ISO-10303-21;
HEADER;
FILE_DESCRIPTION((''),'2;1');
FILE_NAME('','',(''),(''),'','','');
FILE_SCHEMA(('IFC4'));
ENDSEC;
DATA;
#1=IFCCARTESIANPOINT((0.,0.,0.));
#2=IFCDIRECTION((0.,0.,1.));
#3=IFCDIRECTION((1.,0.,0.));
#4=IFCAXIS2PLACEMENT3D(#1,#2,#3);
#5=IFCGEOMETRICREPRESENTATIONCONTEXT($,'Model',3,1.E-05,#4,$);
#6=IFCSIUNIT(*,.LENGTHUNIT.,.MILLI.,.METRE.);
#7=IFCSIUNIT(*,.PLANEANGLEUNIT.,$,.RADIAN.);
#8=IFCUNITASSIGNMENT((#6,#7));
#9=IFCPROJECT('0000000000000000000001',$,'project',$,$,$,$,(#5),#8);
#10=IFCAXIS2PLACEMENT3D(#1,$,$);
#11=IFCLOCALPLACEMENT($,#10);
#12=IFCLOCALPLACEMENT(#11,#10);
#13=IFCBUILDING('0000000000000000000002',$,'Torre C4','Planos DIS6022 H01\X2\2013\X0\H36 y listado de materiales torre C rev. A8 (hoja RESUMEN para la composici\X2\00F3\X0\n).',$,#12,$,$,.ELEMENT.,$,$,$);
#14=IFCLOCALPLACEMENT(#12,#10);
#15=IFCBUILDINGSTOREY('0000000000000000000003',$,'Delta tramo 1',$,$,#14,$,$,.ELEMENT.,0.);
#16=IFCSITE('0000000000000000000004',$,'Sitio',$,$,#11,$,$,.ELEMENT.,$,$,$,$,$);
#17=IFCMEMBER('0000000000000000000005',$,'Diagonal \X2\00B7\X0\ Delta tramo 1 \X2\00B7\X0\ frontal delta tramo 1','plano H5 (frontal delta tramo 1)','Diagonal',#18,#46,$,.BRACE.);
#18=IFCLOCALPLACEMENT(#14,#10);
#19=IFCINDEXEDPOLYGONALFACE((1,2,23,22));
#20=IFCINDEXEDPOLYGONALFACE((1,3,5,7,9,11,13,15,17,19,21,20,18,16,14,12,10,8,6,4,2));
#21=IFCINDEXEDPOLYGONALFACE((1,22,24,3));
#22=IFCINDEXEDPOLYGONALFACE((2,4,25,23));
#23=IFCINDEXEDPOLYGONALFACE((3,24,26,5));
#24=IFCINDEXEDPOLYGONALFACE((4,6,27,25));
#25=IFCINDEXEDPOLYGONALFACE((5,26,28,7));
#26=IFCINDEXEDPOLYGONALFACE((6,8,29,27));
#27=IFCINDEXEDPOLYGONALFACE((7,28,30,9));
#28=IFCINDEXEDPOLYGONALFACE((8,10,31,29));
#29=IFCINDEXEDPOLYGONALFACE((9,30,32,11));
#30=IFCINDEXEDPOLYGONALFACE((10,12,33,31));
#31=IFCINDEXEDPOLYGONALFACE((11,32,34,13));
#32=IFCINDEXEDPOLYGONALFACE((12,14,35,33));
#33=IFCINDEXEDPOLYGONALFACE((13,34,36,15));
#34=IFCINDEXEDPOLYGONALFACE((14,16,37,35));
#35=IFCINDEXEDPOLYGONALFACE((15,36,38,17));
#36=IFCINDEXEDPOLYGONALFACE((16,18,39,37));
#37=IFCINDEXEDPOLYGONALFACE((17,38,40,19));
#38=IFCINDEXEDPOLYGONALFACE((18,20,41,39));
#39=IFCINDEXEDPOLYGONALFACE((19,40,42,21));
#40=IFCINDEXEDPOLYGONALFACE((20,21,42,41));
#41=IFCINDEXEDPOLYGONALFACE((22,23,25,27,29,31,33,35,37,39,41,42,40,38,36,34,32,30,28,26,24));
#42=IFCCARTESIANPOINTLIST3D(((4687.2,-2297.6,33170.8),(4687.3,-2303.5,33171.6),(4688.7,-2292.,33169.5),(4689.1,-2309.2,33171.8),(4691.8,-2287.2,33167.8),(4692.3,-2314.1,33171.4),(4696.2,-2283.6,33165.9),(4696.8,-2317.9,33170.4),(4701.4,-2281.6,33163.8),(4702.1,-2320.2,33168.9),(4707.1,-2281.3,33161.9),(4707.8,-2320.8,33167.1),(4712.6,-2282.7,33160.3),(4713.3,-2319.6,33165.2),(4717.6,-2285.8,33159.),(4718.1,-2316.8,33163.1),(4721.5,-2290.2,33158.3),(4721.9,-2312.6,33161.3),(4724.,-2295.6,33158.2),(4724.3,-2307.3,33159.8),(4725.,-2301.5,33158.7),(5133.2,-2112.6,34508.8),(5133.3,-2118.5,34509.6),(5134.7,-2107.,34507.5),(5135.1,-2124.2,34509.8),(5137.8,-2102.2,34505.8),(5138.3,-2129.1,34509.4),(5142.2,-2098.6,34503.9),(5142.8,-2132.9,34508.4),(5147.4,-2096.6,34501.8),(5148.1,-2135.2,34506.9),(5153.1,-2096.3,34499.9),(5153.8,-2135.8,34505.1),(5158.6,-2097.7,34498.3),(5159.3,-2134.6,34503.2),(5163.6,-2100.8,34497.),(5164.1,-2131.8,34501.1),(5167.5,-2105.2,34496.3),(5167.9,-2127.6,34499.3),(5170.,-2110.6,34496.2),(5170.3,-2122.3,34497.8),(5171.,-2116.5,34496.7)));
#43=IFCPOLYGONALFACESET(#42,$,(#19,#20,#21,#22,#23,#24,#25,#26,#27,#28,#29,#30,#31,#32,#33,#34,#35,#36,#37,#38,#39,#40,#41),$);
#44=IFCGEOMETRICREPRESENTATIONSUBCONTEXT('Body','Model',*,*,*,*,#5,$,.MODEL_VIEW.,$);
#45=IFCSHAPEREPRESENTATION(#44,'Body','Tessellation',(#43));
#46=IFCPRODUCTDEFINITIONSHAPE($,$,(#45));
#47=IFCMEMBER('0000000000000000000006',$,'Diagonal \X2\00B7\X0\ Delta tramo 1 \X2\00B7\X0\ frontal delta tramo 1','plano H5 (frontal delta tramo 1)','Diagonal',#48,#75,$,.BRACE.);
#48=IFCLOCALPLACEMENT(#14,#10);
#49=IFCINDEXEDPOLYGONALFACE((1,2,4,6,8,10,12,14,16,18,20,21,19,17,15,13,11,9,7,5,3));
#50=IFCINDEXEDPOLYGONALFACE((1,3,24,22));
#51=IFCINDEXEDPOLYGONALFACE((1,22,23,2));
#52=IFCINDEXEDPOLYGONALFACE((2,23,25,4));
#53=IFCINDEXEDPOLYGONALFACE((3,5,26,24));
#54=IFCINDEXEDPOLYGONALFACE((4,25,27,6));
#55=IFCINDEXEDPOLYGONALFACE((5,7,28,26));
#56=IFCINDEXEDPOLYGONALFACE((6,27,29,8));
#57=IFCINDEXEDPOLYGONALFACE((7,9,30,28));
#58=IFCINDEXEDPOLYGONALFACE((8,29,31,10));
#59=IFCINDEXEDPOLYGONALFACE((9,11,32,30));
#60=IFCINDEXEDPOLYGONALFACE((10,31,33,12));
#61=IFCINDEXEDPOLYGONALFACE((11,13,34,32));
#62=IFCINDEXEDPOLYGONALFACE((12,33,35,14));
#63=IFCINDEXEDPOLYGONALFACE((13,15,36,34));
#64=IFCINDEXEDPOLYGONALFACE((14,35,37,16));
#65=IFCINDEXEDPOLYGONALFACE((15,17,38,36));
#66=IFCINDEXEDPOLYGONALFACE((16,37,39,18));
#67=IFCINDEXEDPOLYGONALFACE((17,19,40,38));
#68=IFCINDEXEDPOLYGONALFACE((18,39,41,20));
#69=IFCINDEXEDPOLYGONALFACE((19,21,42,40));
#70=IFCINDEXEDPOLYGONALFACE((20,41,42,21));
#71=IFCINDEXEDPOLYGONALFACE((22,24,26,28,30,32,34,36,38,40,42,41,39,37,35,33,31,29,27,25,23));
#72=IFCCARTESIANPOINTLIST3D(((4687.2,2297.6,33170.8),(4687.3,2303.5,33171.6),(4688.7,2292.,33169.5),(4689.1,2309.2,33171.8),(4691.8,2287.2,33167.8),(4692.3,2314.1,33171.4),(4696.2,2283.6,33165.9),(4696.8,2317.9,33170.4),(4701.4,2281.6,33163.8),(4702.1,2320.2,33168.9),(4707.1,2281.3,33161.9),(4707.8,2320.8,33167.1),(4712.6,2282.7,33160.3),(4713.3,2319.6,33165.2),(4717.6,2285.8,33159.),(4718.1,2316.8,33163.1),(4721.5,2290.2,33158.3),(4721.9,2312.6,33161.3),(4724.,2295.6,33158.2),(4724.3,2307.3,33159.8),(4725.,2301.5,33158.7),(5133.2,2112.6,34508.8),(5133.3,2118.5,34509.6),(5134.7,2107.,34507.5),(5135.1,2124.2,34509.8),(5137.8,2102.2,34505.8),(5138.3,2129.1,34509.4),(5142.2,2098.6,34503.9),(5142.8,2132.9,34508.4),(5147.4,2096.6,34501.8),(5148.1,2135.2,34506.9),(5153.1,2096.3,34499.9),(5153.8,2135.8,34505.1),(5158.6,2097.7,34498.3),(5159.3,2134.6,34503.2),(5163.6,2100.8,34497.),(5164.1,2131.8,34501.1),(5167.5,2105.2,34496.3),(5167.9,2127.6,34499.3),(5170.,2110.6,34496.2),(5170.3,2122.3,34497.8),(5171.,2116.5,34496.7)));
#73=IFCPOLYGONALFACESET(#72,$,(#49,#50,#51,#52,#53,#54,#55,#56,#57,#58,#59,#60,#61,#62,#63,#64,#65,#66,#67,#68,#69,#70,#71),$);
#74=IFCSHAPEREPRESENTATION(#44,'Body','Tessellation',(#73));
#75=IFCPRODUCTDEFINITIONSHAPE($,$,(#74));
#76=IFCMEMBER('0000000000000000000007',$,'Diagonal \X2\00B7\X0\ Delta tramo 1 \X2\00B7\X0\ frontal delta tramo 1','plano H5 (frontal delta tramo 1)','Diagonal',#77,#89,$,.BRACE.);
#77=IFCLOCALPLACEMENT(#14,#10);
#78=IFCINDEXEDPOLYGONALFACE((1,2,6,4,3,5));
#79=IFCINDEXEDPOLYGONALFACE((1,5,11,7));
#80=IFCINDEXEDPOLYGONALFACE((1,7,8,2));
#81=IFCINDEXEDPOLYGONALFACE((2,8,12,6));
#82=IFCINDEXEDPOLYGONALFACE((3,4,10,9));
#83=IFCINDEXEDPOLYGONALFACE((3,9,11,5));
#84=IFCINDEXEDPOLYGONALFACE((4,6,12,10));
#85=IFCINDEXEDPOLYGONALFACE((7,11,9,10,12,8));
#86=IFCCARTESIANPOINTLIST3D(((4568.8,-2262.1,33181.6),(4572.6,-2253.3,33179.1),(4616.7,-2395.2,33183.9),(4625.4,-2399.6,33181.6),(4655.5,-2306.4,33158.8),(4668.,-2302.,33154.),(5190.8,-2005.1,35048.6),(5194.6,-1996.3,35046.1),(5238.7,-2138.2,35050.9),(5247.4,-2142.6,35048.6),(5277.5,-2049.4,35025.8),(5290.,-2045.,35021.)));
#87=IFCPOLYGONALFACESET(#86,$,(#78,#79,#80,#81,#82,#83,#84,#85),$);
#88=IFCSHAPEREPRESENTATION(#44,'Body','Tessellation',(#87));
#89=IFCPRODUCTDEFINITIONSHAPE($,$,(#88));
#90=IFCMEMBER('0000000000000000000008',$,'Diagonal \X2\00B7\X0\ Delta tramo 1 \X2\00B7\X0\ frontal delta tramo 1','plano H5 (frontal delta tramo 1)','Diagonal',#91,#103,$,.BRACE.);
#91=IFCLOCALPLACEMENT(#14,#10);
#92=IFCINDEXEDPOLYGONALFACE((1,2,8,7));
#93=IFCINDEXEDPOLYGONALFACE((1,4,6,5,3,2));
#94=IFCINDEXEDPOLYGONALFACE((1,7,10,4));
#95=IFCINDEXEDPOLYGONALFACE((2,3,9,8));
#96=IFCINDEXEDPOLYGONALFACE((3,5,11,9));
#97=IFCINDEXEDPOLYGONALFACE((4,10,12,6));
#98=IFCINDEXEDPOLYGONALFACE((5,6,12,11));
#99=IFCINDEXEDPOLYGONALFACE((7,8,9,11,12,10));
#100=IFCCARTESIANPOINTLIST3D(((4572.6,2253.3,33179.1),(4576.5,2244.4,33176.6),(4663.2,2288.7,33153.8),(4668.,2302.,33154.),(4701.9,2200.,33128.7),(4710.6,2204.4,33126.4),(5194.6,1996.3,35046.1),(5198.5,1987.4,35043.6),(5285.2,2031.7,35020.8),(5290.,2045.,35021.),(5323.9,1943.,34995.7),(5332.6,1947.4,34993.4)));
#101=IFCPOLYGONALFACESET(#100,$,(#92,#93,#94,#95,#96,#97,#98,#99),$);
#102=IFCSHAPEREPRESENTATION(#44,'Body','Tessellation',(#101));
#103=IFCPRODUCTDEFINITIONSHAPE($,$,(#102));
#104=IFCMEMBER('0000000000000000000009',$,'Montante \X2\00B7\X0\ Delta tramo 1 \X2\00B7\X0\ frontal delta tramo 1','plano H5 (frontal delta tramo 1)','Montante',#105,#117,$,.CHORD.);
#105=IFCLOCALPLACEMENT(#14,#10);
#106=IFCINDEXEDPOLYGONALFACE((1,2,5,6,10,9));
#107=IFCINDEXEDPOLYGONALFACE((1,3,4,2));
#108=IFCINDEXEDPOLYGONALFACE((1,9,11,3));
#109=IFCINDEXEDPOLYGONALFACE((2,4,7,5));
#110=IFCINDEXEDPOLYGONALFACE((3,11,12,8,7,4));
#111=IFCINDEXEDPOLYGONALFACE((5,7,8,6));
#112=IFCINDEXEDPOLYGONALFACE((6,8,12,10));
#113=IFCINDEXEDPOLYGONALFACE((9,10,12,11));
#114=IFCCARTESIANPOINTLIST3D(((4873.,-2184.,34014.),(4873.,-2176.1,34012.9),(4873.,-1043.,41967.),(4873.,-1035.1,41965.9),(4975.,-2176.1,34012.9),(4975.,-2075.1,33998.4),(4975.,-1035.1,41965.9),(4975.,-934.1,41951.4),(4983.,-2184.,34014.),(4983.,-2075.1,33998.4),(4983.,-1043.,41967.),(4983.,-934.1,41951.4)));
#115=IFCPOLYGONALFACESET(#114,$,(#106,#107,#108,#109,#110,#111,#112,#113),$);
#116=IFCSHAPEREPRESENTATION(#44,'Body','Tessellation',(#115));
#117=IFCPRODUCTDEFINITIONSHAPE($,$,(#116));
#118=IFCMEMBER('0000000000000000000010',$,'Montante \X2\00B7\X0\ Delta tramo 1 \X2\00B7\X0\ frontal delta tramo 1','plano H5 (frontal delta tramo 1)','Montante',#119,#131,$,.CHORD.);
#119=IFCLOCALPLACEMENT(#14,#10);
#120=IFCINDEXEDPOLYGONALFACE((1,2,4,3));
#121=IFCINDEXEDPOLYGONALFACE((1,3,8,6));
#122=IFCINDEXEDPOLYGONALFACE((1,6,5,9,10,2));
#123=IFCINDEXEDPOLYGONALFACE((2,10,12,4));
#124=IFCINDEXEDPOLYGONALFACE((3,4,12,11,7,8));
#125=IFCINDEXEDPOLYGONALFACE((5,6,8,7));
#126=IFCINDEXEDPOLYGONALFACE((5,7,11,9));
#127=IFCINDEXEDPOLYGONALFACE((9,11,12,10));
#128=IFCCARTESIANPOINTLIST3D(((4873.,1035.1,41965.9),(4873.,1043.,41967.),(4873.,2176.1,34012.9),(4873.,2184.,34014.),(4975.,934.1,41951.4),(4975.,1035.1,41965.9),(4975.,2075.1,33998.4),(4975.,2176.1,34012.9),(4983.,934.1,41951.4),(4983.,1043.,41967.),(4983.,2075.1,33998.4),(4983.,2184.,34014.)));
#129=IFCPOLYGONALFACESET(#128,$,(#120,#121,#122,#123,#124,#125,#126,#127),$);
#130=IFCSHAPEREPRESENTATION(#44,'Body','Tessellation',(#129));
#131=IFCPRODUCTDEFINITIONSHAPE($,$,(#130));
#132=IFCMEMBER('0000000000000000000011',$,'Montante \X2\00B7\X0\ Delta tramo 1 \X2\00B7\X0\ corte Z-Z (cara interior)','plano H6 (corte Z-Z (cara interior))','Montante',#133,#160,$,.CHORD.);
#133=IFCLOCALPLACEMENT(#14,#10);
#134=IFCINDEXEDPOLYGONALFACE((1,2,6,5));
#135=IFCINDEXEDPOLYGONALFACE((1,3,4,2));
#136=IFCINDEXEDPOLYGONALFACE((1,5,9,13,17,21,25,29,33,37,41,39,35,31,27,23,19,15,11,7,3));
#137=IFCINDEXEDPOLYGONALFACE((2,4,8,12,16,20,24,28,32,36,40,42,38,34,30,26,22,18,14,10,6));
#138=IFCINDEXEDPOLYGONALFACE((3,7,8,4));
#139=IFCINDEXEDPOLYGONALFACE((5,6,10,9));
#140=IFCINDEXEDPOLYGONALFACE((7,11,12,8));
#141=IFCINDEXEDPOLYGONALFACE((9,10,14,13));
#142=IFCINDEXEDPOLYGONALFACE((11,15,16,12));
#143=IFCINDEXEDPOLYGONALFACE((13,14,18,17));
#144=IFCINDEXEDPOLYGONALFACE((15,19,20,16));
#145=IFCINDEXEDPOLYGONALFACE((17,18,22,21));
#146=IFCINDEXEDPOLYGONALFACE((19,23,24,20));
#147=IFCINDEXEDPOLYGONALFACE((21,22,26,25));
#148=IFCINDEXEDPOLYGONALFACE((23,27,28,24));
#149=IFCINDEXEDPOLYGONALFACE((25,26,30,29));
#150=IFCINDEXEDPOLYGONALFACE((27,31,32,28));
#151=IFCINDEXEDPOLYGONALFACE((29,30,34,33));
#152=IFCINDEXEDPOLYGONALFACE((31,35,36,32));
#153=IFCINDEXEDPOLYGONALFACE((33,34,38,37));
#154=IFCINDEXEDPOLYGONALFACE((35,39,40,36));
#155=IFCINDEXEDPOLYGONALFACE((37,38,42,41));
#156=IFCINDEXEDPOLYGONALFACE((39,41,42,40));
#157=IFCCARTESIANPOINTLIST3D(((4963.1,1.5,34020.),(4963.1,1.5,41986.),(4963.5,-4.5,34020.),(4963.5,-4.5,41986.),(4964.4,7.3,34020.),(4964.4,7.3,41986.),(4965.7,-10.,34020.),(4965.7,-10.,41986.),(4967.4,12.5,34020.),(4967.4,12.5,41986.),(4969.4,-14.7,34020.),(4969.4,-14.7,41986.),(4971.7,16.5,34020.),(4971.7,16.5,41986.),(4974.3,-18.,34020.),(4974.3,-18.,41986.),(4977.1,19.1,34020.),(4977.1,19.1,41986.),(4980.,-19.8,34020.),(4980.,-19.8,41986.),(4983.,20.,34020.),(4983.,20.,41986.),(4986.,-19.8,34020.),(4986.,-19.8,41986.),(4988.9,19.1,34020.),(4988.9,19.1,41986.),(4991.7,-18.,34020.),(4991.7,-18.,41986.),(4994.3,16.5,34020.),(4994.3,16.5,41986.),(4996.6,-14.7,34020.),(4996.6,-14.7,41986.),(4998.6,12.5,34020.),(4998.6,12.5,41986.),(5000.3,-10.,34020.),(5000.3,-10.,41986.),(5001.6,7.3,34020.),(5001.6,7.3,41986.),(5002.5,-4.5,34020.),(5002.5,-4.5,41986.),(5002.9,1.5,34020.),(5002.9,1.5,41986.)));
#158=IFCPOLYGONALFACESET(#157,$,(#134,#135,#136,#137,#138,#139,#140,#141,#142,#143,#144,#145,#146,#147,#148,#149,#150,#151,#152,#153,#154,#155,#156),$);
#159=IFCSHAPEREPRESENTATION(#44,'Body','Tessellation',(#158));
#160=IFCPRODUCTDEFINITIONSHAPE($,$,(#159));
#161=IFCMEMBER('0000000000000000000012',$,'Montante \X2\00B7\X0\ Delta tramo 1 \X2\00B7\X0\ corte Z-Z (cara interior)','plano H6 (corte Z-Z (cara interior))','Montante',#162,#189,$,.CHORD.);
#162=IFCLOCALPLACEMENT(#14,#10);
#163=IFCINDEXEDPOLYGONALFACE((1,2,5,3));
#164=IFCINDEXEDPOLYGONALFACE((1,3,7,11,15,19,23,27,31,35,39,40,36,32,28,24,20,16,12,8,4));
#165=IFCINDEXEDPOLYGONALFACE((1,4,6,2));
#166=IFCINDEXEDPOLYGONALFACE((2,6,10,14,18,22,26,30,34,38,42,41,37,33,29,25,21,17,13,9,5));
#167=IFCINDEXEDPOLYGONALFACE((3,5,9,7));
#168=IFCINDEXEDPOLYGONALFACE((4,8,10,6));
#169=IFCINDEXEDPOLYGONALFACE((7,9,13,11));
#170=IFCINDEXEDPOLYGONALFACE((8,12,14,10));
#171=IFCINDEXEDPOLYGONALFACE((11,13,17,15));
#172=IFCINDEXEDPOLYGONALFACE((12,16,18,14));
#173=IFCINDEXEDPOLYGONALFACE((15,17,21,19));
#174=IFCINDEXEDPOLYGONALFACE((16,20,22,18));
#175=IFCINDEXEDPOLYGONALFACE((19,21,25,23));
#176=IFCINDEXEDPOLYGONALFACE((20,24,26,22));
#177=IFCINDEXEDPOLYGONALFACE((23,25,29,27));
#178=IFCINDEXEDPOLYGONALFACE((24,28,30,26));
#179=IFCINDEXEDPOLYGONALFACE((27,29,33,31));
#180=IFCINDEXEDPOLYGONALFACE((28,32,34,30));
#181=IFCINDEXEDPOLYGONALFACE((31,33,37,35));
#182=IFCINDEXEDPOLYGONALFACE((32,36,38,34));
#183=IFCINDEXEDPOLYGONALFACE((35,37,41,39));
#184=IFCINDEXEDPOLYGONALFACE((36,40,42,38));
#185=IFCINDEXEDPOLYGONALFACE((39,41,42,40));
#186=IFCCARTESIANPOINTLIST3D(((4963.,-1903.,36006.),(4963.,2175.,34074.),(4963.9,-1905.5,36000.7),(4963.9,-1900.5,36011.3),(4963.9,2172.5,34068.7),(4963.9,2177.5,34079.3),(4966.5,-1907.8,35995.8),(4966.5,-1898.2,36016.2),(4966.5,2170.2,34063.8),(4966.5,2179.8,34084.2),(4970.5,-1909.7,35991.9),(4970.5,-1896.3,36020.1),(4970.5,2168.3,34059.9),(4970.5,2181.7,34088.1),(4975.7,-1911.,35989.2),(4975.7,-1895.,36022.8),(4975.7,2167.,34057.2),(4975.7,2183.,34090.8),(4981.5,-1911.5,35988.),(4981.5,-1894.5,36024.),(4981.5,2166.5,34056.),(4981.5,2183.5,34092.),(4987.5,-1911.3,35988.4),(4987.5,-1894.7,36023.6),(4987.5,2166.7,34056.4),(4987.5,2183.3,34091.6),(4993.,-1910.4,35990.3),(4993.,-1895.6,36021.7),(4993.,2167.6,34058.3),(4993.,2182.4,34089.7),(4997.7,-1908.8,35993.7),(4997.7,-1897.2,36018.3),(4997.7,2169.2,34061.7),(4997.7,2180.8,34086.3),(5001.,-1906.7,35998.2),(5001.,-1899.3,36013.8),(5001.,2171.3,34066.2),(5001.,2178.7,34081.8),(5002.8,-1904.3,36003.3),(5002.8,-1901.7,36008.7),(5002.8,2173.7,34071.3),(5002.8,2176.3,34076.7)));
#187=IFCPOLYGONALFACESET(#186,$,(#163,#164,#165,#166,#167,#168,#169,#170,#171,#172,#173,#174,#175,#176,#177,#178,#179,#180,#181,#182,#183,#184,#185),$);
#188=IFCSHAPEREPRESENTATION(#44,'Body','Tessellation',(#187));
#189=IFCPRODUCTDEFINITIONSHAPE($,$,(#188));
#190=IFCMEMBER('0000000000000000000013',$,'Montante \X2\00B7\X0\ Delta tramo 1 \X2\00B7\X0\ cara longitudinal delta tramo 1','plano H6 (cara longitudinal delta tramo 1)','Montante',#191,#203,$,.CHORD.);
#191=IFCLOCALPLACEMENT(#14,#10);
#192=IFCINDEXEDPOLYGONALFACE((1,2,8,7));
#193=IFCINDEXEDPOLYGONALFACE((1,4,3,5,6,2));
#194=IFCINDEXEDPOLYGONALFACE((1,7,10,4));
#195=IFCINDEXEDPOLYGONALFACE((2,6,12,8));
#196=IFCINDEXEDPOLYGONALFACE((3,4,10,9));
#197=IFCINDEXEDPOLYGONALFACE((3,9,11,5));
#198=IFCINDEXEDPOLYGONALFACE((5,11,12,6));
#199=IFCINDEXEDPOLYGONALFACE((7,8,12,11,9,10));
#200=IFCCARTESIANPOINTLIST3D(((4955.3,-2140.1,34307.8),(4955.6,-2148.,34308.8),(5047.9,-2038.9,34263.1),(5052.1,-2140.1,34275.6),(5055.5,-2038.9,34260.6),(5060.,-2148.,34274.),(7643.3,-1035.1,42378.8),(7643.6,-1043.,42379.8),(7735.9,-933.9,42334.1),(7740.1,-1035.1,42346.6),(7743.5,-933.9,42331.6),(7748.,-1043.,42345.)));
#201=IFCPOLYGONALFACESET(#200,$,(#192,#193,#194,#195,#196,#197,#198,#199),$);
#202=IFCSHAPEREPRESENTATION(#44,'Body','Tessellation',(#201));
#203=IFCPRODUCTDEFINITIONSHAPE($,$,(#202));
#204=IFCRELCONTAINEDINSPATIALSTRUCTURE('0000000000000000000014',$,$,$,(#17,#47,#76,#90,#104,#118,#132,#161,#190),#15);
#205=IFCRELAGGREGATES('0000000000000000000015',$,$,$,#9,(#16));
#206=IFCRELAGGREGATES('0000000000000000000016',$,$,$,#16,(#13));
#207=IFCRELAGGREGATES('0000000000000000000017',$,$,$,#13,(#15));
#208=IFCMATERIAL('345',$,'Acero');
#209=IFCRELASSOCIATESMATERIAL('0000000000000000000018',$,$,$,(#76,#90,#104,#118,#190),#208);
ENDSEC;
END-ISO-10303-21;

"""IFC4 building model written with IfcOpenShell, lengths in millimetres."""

from ifc_helpers import new_model, si_unit, frame, frame_2d, origin, origin_with_axes, place, context, subcontext, project, spatial, circle, l_section, extrude, material, element, save


model = new_model("IFC4")

# Units and contexts
model_context = context("Model", 3, precision=1e-05, world=origin_with_axes())
body_context = subcontext(model_context, "Body", "Model", "MODEL_VIEW")
ifc_project = project(units=[si_unit("LENGTHUNIT", "METRE", prefix="MILLI"), si_unit("PLANEANGLEUNIT", "RADIAN")], contexts=[model_context])

# Site, building, storey
site_placement = place(None, origin())
site = spatial("IfcSite", under=ifc_project, at=site_placement, Name="Sitio", CompositionType="ELEMENT")
building_placement = place(site_placement, origin())
building = spatial("IfcBuilding", under=site, at=building_placement, Name="Torre C4", Description="Planos DIS6022 H01–H36 y listado de materiales torre C rev. A8 (hoja RESUMEN para la composición).", CompositionType="ELEMENT")
storey_placement = place(building_placement, origin())
storey = spatial("IfcBuildingStorey", under=building, at=storey_placement, Name="Delta tramo 1", CompositionType="ELEMENT", Elevation=0.0)

# Members
for number, where, z_axis, x_axis, name in (
    (1, (4706.0, -2301.0, 33165.0), (0.313542, 0.130057, 0.940626), (-0.863292, 0.451616, 0.225321), "Diagonal · Delta tramo 1 · frontal delta tramo 1"),
    (2, (4706.0, 2301.0, 33165.0), (0.313542, -0.130057, 0.940626), (-0.863292, -0.451616, 0.225321), "Diagonal · Delta tramo 1 · frontal delta tramo 1"),
):
    element("IfcMember", number, at=place(storey_placement, frame(where, z_axis=z_axis, x_axis=x_axis)), inside=storey, Name=name, Description="plano H5 (frontal delta tramo 1)", ObjectType="Diagonal", PredefinedType="BRACE", context=body_context, shape_type="SweptSolid", body=[
        extrude(circle(Radius=20.0), None, (0.0, 0.0, 1.0), 1422.5),
    ])
ifc_material_1 = material(Name="345", Category="Acero")
for number, where, z_axis, x_axis, name in (
    (3, (4668.0, -2302.0, 33154.0), (0.313414, 0.129497, 0.940746), (-0.867067, 0.443015, 0.227885), "Diagonal · Delta tramo 1 · frontal delta tramo 1"),
    (4, (4668.0, 2302.0, 33154.0), (0.313414, -0.129497, 0.940746), (-0.867067, -0.443015, 0.227885), "Diagonal · Delta tramo 1 · frontal delta tramo 1"),
):
    element("IfcMember", number, at=place(storey_placement, frame(where, z_axis=z_axis, x_axis=x_axis)), inside=storey, material=ifc_material_1, Name=name, Description="plano H5 (frontal delta tramo 1)", ObjectType="Diagonal", PredefinedType="BRACE", context=body_context, shape_type="SweptSolid", body=[
        extrude(l_section(Depth=110.0, Width=110.0, Thickness=10.0, at=frame_2d((55.0, 55.0))), None, (0.0, 0.0, 1.0), 1984.6),
    ])
for number, where, z_axis, x_axis, name in (
    (5, (4983.0, -2184.0, 34014.0), (0.0, 0.142014, 0.989865), (0.0, 0.989865, -0.142014), "Montante · Delta tramo 1 · frontal delta tramo 1"),
    (6, (4983.0, 2184.0, 34014.0), (0.0, -0.142014, 0.989865), (-1.0, 0.0, 0.0), "Montante · Delta tramo 1 · frontal delta tramo 1"),
):
    element("IfcMember", number, at=place(storey_placement, frame(where, z_axis=z_axis, x_axis=x_axis)), inside=storey, material=ifc_material_1, Name=name, Description="plano H5 (frontal delta tramo 1)", ObjectType="Montante", PredefinedType="CHORD", context=body_context, shape_type="SweptSolid", body=[
        extrude(l_section(Depth=110.0, Width=110.0, Thickness=8.0, at=frame_2d((55.0, 55.0))), None, (0.0, 0.0, 1.0), 8034.4),
    ])
member_1_placement = place(storey_placement, frame((4983.0, 0.0, 34020.0), z_axis=(0.0, 0.0, 1.0), x_axis=(0.0, 1.0, 0.0)))
element("IfcMember", 7, at=member_1_placement, inside=storey, Name="Montante · Delta tramo 1 · corte Z-Z (cara interior)", Description="plano H6 (corte Z-Z (cara interior))", ObjectType="Montante", PredefinedType="CHORD", context=body_context, shape_type="SweptSolid", body=[
    extrude(circle(Radius=20.0), None, (0.0, 0.0, 1.0), 7966.0),
])
member_2_placement = place(storey_placement, frame((4983.0, 2175.0, 34074.0), z_axis=(0.0, -0.903711, 0.428144), x_axis=(-1.0, 0.0, 0.0)))
element("IfcMember", 8, at=member_2_placement, inside=storey, Name="Montante · Delta tramo 1 · corte Z-Z (cara interior)", Description="plano H6 (corte Z-Z (cara interior))", ObjectType="Montante", PredefinedType="CHORD", context=body_context, shape_type="SweptSolid", body=[
    extrude(circle(Radius=20.0), None, (0.0, 0.0, 1.0), 4512.5),
])
member_3_placement = place(storey_placement, frame((5060.0, -2148.0, 34274.0), z_axis=(0.313348, 0.128813, 0.940861), x_axis=(-0.040703, 0.991669, -0.122214)))
element("IfcMember", 9, at=member_3_placement, inside=storey, material=ifc_material_1, Name="Montante · Delta tramo 1 · cara longitudinal delta tramo 1", Description="plano H6 (cara longitudinal delta tramo 1)", ObjectType="Montante", PredefinedType="CHORD", context=body_context, shape_type="SweptSolid", body=[
    extrude(l_section(Depth=110.0, Width=110.0, Thickness=8.0, at=frame_2d((55.0, 55.0))), None, (0.0, 0.0, 1.0), 8578.3),
])

save(model, "model.ifc")
